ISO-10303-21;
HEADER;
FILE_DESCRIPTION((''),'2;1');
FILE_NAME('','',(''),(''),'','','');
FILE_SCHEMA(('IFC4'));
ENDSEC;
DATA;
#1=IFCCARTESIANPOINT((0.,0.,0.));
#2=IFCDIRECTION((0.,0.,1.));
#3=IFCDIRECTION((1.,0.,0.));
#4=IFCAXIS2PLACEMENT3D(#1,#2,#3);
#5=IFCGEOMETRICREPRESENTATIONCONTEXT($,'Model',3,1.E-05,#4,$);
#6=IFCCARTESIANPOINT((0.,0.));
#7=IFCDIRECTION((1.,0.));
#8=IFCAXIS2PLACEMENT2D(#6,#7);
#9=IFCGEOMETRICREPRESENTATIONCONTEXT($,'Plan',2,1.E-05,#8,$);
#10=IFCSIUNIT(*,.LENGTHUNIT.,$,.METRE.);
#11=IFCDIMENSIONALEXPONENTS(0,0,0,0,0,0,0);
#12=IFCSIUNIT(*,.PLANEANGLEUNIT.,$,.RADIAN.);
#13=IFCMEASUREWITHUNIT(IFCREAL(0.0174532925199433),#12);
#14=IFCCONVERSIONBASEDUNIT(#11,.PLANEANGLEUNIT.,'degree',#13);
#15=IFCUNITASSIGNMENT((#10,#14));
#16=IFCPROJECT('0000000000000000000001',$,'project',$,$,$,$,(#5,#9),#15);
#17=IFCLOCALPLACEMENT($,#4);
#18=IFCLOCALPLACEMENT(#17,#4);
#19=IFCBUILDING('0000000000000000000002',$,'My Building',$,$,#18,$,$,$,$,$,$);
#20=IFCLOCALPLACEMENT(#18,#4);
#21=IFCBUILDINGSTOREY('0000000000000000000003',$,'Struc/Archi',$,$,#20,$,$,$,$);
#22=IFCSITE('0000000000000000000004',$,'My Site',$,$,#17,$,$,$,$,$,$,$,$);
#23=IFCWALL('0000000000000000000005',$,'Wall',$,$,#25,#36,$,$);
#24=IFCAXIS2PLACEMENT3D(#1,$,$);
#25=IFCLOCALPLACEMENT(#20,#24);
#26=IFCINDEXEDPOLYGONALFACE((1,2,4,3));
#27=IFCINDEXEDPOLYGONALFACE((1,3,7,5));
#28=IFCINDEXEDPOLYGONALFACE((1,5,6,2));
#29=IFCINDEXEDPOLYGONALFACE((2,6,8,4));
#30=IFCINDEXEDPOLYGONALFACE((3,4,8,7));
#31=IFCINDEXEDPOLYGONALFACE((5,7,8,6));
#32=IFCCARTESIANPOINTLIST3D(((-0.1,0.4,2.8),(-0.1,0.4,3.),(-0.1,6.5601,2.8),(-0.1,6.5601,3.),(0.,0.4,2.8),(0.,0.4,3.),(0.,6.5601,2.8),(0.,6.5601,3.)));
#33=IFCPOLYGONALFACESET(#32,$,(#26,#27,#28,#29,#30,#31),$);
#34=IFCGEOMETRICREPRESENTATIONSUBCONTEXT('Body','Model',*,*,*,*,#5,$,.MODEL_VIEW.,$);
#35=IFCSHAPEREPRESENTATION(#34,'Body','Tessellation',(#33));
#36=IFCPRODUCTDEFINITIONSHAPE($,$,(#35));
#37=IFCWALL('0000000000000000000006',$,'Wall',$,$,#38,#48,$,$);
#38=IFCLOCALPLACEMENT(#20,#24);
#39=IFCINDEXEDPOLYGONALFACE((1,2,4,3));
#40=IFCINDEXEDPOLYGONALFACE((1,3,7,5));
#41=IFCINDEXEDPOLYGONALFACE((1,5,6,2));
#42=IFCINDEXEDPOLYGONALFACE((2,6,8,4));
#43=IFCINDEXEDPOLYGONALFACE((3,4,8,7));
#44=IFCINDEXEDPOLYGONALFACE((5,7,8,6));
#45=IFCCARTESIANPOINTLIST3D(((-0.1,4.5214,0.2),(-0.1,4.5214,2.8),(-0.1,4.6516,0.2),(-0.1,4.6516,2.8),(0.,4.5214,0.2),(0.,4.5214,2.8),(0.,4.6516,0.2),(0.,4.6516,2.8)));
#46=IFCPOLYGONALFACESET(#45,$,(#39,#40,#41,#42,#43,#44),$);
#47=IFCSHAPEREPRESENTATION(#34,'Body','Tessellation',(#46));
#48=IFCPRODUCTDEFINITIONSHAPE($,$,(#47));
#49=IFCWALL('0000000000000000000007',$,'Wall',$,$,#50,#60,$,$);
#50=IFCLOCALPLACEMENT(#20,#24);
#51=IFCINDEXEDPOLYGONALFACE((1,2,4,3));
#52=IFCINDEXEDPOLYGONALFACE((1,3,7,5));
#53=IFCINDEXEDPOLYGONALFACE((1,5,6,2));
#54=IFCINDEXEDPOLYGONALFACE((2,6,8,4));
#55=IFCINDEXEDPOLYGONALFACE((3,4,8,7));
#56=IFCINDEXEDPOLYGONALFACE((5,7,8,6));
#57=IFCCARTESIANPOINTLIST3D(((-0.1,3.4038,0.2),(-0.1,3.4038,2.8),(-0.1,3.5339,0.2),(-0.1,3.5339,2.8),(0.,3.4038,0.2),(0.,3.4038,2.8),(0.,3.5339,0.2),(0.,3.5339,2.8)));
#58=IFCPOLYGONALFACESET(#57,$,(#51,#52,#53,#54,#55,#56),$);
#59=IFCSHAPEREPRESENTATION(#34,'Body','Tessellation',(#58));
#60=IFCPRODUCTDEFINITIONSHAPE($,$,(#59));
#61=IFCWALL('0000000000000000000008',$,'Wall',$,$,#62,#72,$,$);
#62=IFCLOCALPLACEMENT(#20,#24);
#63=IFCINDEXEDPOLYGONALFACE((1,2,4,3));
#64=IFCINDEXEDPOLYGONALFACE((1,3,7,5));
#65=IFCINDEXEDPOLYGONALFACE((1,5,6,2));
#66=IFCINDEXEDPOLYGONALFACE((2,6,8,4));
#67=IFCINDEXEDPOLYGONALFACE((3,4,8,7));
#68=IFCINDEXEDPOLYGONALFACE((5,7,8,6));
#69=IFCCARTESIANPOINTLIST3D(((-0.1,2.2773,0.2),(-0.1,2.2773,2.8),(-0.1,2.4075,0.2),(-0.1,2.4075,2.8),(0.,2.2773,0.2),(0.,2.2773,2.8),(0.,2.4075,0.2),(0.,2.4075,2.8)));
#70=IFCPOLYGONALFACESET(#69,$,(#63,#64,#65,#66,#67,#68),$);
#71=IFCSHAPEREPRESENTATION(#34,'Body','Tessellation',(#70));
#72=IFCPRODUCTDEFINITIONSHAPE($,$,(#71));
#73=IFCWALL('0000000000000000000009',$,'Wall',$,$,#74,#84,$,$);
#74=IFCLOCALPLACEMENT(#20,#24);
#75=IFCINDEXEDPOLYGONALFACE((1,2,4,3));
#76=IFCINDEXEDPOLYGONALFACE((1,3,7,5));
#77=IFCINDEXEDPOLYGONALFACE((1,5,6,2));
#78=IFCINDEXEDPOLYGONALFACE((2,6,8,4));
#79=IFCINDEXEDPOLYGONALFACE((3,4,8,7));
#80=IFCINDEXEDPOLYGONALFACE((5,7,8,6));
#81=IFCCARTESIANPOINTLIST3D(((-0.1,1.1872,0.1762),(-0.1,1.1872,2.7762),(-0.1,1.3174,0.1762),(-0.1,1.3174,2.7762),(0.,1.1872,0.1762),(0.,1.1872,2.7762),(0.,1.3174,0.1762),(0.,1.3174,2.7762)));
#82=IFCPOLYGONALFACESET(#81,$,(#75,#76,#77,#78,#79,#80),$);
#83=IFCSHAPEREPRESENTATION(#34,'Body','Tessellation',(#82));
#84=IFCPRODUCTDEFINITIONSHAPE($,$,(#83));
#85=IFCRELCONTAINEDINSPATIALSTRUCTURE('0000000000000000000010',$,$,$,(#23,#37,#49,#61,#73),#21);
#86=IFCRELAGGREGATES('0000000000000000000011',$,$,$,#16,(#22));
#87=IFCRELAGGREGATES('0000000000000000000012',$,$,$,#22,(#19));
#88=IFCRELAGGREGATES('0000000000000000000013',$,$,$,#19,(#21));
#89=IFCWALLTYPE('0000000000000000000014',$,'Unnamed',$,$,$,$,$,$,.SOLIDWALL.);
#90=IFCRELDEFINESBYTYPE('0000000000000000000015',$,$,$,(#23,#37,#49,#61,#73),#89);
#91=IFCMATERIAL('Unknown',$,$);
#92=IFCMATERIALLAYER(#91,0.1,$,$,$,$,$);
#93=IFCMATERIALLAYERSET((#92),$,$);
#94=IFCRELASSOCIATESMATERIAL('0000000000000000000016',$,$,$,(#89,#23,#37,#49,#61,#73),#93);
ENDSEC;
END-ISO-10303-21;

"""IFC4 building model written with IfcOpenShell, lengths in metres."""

from ifc_helpers import new_model, entity, si_unit, converted_unit, frame, origin_with_axes, origin_2d_with_axis, place, context, subcontext, project, spatial, line, indexed_curve, outline, extrude, material, layer, layer_set, layer_usage, type_object, element, save


model = new_model("IFC4")

# Units and contexts
model_context = context("Model", 3, precision=1e-05, world=origin_with_axes())
plan_context = context("Plan", 2, precision=1e-05, world=origin_2d_with_axis())
body_context_1 = subcontext(model_context, "Body", "Model", "MODEL_VIEW")
ifc_project = project(units=[si_unit("LENGTHUNIT", "METRE"), converted_unit("PLANEANGLEUNIT", "degree", entity("IfcReal", 0.0174532925199433), si_unit("PLANEANGLEUNIT", "RADIAN"), dimensions=[0, 0, 0, 0, 0, 0, 0])], contexts=[model_context, plan_context])

# Site, building, storey
site_placement = place(None, origin_with_axes())
site = spatial("IfcSite", under=ifc_project, at=site_placement, Name="My Site")
building_placement = place(site_placement, origin_with_axes())
building = spatial("IfcBuilding", under=site, at=building_placement, Name="My Building")
storey_placement = place(building_placement, origin_with_axes())
storey = spatial("IfcBuildingStorey", under=building, at=storey_placement, Name="Struc/Archi")

# Shared definitions
ifc_material = material(Name="Unknown")

# Shared definitions
ifc_layer_1 = layer(ifc_material, 0.1)
ifc_layer_set_1 = layer_set([ifc_layer_1])
wall_type = type_object("IfcWallType", Name="Unnamed", PredefinedType="SOLIDWALL", material=ifc_layer_set_1)

# Walls
ifc_layer_usage_1 = layer_usage(ifc_layer_set_1, "AXIS2", "POSITIVE", 0.0)
wall_1_placement = place(storey_placement, frame((-0.1, 6.5601, 2.8), z_axis=(0.0, 0.0, 1.0), x_axis=(0.0, -1.0, 0.0)))
element("IfcWall", 1, at=wall_1_placement, inside=storey, type_object=wall_type, material=ifc_layer_usage_1, Name="Wall", context=body_context_1, shape_type="SweptSolid", body=[
    extrude(outline(indexed_curve([(0.0, 0.0), (0.0, 0.1), (6.1601, 0.1), (6.1601, 0.0)], segments=[line(1, 2, 3, 4, 1)])), origin_with_axes(), (0.0, 0.0, 1.0), 0.2),
])
ifc_layer_usage_2 = layer_usage(ifc_layer_set_1, "AXIS2", "POSITIVE", 0.0)
wall_2_placement = place(storey_placement, frame((-0.1, 4.6516, 0.2), z_axis=(0.0, 0.0, 1.0), x_axis=(0.0, -1.0, 0.0)))
element("IfcWall", 2, at=wall_2_placement, inside=storey, type_object=wall_type, material=ifc_layer_usage_2, Name="Wall", context=body_context_1, shape_type="SweptSolid", body=[
    extrude(outline(indexed_curve([(0.0, 0.0), (0.0, 0.1), (0.1301, 0.1), (0.1301, 0.0)], segments=[line(1, 2, 3, 4, 1)])), origin_with_axes(), (0.0, 0.0, 1.0), 2.6),
])
ifc_layer_usage_3 = layer_usage(ifc_layer_set_1, "AXIS2", "POSITIVE", 0.0)
wall_3_placement = place(storey_placement, frame((-0.1, 3.5339, 0.2), z_axis=(0.0, 0.0, 1.0), x_axis=(0.0, -1.0, 0.0)))
element("IfcWall", 3, at=wall_3_placement, inside=storey, type_object=wall_type, material=ifc_layer_usage_3, Name="Wall", context=body_context_1, shape_type="SweptSolid", body=[
    extrude(outline(indexed_curve([(0.0, 0.0), (0.0, 0.1), (0.1301, 0.1), (0.1301, 0.0)], segments=[line(1, 2, 3, 4, 1)])), origin_with_axes(), (0.0, 0.0, 1.0), 2.6),
])
ifc_layer_usage_4 = layer_usage(ifc_layer_set_1, "AXIS2", "POSITIVE", 0.0)
wall_4_placement = place(storey_placement, frame((-0.1, 2.4075, 0.2), z_axis=(0.0, 0.0, 1.0), x_axis=(0.0, -1.0, 0.0)))
element("IfcWall", 4, at=wall_4_placement, inside=storey, type_object=wall_type, material=ifc_layer_usage_4, Name="Wall", context=body_context_1, shape_type="SweptSolid", body=[
    extrude(outline(indexed_curve([(0.0, 0.0), (0.0, 0.1), (0.1301, 0.1), (0.1301, 0.0)], segments=[line(1, 2, 3, 4, 1)])), origin_with_axes(), (0.0, 0.0, 1.0), 2.6),
])
ifc_layer_usage_5 = layer_usage(ifc_layer_set_1, "AXIS2", "POSITIVE", 0.0)
wall_5_placement = place(storey_placement, frame((-0.1, 1.3174, 0.1762), z_axis=(0.0, 0.0, 1.0), x_axis=(0.0, -1.0, 0.0)))
element("IfcWall", 5, at=wall_5_placement, inside=storey, type_object=wall_type, material=ifc_layer_usage_5, Name="Wall", context=body_context_1, shape_type="SweptSolid", body=[
    extrude(outline(indexed_curve([(0.0, 0.0), (0.0, 0.1), (0.1301, 0.1), (0.1301, 0.0)], segments=[line(1, 2, 3, 4, 1)])), origin_with_axes(), (0.0, 0.0, 1.0), 2.6),
])

save(model, "model.ifc")
